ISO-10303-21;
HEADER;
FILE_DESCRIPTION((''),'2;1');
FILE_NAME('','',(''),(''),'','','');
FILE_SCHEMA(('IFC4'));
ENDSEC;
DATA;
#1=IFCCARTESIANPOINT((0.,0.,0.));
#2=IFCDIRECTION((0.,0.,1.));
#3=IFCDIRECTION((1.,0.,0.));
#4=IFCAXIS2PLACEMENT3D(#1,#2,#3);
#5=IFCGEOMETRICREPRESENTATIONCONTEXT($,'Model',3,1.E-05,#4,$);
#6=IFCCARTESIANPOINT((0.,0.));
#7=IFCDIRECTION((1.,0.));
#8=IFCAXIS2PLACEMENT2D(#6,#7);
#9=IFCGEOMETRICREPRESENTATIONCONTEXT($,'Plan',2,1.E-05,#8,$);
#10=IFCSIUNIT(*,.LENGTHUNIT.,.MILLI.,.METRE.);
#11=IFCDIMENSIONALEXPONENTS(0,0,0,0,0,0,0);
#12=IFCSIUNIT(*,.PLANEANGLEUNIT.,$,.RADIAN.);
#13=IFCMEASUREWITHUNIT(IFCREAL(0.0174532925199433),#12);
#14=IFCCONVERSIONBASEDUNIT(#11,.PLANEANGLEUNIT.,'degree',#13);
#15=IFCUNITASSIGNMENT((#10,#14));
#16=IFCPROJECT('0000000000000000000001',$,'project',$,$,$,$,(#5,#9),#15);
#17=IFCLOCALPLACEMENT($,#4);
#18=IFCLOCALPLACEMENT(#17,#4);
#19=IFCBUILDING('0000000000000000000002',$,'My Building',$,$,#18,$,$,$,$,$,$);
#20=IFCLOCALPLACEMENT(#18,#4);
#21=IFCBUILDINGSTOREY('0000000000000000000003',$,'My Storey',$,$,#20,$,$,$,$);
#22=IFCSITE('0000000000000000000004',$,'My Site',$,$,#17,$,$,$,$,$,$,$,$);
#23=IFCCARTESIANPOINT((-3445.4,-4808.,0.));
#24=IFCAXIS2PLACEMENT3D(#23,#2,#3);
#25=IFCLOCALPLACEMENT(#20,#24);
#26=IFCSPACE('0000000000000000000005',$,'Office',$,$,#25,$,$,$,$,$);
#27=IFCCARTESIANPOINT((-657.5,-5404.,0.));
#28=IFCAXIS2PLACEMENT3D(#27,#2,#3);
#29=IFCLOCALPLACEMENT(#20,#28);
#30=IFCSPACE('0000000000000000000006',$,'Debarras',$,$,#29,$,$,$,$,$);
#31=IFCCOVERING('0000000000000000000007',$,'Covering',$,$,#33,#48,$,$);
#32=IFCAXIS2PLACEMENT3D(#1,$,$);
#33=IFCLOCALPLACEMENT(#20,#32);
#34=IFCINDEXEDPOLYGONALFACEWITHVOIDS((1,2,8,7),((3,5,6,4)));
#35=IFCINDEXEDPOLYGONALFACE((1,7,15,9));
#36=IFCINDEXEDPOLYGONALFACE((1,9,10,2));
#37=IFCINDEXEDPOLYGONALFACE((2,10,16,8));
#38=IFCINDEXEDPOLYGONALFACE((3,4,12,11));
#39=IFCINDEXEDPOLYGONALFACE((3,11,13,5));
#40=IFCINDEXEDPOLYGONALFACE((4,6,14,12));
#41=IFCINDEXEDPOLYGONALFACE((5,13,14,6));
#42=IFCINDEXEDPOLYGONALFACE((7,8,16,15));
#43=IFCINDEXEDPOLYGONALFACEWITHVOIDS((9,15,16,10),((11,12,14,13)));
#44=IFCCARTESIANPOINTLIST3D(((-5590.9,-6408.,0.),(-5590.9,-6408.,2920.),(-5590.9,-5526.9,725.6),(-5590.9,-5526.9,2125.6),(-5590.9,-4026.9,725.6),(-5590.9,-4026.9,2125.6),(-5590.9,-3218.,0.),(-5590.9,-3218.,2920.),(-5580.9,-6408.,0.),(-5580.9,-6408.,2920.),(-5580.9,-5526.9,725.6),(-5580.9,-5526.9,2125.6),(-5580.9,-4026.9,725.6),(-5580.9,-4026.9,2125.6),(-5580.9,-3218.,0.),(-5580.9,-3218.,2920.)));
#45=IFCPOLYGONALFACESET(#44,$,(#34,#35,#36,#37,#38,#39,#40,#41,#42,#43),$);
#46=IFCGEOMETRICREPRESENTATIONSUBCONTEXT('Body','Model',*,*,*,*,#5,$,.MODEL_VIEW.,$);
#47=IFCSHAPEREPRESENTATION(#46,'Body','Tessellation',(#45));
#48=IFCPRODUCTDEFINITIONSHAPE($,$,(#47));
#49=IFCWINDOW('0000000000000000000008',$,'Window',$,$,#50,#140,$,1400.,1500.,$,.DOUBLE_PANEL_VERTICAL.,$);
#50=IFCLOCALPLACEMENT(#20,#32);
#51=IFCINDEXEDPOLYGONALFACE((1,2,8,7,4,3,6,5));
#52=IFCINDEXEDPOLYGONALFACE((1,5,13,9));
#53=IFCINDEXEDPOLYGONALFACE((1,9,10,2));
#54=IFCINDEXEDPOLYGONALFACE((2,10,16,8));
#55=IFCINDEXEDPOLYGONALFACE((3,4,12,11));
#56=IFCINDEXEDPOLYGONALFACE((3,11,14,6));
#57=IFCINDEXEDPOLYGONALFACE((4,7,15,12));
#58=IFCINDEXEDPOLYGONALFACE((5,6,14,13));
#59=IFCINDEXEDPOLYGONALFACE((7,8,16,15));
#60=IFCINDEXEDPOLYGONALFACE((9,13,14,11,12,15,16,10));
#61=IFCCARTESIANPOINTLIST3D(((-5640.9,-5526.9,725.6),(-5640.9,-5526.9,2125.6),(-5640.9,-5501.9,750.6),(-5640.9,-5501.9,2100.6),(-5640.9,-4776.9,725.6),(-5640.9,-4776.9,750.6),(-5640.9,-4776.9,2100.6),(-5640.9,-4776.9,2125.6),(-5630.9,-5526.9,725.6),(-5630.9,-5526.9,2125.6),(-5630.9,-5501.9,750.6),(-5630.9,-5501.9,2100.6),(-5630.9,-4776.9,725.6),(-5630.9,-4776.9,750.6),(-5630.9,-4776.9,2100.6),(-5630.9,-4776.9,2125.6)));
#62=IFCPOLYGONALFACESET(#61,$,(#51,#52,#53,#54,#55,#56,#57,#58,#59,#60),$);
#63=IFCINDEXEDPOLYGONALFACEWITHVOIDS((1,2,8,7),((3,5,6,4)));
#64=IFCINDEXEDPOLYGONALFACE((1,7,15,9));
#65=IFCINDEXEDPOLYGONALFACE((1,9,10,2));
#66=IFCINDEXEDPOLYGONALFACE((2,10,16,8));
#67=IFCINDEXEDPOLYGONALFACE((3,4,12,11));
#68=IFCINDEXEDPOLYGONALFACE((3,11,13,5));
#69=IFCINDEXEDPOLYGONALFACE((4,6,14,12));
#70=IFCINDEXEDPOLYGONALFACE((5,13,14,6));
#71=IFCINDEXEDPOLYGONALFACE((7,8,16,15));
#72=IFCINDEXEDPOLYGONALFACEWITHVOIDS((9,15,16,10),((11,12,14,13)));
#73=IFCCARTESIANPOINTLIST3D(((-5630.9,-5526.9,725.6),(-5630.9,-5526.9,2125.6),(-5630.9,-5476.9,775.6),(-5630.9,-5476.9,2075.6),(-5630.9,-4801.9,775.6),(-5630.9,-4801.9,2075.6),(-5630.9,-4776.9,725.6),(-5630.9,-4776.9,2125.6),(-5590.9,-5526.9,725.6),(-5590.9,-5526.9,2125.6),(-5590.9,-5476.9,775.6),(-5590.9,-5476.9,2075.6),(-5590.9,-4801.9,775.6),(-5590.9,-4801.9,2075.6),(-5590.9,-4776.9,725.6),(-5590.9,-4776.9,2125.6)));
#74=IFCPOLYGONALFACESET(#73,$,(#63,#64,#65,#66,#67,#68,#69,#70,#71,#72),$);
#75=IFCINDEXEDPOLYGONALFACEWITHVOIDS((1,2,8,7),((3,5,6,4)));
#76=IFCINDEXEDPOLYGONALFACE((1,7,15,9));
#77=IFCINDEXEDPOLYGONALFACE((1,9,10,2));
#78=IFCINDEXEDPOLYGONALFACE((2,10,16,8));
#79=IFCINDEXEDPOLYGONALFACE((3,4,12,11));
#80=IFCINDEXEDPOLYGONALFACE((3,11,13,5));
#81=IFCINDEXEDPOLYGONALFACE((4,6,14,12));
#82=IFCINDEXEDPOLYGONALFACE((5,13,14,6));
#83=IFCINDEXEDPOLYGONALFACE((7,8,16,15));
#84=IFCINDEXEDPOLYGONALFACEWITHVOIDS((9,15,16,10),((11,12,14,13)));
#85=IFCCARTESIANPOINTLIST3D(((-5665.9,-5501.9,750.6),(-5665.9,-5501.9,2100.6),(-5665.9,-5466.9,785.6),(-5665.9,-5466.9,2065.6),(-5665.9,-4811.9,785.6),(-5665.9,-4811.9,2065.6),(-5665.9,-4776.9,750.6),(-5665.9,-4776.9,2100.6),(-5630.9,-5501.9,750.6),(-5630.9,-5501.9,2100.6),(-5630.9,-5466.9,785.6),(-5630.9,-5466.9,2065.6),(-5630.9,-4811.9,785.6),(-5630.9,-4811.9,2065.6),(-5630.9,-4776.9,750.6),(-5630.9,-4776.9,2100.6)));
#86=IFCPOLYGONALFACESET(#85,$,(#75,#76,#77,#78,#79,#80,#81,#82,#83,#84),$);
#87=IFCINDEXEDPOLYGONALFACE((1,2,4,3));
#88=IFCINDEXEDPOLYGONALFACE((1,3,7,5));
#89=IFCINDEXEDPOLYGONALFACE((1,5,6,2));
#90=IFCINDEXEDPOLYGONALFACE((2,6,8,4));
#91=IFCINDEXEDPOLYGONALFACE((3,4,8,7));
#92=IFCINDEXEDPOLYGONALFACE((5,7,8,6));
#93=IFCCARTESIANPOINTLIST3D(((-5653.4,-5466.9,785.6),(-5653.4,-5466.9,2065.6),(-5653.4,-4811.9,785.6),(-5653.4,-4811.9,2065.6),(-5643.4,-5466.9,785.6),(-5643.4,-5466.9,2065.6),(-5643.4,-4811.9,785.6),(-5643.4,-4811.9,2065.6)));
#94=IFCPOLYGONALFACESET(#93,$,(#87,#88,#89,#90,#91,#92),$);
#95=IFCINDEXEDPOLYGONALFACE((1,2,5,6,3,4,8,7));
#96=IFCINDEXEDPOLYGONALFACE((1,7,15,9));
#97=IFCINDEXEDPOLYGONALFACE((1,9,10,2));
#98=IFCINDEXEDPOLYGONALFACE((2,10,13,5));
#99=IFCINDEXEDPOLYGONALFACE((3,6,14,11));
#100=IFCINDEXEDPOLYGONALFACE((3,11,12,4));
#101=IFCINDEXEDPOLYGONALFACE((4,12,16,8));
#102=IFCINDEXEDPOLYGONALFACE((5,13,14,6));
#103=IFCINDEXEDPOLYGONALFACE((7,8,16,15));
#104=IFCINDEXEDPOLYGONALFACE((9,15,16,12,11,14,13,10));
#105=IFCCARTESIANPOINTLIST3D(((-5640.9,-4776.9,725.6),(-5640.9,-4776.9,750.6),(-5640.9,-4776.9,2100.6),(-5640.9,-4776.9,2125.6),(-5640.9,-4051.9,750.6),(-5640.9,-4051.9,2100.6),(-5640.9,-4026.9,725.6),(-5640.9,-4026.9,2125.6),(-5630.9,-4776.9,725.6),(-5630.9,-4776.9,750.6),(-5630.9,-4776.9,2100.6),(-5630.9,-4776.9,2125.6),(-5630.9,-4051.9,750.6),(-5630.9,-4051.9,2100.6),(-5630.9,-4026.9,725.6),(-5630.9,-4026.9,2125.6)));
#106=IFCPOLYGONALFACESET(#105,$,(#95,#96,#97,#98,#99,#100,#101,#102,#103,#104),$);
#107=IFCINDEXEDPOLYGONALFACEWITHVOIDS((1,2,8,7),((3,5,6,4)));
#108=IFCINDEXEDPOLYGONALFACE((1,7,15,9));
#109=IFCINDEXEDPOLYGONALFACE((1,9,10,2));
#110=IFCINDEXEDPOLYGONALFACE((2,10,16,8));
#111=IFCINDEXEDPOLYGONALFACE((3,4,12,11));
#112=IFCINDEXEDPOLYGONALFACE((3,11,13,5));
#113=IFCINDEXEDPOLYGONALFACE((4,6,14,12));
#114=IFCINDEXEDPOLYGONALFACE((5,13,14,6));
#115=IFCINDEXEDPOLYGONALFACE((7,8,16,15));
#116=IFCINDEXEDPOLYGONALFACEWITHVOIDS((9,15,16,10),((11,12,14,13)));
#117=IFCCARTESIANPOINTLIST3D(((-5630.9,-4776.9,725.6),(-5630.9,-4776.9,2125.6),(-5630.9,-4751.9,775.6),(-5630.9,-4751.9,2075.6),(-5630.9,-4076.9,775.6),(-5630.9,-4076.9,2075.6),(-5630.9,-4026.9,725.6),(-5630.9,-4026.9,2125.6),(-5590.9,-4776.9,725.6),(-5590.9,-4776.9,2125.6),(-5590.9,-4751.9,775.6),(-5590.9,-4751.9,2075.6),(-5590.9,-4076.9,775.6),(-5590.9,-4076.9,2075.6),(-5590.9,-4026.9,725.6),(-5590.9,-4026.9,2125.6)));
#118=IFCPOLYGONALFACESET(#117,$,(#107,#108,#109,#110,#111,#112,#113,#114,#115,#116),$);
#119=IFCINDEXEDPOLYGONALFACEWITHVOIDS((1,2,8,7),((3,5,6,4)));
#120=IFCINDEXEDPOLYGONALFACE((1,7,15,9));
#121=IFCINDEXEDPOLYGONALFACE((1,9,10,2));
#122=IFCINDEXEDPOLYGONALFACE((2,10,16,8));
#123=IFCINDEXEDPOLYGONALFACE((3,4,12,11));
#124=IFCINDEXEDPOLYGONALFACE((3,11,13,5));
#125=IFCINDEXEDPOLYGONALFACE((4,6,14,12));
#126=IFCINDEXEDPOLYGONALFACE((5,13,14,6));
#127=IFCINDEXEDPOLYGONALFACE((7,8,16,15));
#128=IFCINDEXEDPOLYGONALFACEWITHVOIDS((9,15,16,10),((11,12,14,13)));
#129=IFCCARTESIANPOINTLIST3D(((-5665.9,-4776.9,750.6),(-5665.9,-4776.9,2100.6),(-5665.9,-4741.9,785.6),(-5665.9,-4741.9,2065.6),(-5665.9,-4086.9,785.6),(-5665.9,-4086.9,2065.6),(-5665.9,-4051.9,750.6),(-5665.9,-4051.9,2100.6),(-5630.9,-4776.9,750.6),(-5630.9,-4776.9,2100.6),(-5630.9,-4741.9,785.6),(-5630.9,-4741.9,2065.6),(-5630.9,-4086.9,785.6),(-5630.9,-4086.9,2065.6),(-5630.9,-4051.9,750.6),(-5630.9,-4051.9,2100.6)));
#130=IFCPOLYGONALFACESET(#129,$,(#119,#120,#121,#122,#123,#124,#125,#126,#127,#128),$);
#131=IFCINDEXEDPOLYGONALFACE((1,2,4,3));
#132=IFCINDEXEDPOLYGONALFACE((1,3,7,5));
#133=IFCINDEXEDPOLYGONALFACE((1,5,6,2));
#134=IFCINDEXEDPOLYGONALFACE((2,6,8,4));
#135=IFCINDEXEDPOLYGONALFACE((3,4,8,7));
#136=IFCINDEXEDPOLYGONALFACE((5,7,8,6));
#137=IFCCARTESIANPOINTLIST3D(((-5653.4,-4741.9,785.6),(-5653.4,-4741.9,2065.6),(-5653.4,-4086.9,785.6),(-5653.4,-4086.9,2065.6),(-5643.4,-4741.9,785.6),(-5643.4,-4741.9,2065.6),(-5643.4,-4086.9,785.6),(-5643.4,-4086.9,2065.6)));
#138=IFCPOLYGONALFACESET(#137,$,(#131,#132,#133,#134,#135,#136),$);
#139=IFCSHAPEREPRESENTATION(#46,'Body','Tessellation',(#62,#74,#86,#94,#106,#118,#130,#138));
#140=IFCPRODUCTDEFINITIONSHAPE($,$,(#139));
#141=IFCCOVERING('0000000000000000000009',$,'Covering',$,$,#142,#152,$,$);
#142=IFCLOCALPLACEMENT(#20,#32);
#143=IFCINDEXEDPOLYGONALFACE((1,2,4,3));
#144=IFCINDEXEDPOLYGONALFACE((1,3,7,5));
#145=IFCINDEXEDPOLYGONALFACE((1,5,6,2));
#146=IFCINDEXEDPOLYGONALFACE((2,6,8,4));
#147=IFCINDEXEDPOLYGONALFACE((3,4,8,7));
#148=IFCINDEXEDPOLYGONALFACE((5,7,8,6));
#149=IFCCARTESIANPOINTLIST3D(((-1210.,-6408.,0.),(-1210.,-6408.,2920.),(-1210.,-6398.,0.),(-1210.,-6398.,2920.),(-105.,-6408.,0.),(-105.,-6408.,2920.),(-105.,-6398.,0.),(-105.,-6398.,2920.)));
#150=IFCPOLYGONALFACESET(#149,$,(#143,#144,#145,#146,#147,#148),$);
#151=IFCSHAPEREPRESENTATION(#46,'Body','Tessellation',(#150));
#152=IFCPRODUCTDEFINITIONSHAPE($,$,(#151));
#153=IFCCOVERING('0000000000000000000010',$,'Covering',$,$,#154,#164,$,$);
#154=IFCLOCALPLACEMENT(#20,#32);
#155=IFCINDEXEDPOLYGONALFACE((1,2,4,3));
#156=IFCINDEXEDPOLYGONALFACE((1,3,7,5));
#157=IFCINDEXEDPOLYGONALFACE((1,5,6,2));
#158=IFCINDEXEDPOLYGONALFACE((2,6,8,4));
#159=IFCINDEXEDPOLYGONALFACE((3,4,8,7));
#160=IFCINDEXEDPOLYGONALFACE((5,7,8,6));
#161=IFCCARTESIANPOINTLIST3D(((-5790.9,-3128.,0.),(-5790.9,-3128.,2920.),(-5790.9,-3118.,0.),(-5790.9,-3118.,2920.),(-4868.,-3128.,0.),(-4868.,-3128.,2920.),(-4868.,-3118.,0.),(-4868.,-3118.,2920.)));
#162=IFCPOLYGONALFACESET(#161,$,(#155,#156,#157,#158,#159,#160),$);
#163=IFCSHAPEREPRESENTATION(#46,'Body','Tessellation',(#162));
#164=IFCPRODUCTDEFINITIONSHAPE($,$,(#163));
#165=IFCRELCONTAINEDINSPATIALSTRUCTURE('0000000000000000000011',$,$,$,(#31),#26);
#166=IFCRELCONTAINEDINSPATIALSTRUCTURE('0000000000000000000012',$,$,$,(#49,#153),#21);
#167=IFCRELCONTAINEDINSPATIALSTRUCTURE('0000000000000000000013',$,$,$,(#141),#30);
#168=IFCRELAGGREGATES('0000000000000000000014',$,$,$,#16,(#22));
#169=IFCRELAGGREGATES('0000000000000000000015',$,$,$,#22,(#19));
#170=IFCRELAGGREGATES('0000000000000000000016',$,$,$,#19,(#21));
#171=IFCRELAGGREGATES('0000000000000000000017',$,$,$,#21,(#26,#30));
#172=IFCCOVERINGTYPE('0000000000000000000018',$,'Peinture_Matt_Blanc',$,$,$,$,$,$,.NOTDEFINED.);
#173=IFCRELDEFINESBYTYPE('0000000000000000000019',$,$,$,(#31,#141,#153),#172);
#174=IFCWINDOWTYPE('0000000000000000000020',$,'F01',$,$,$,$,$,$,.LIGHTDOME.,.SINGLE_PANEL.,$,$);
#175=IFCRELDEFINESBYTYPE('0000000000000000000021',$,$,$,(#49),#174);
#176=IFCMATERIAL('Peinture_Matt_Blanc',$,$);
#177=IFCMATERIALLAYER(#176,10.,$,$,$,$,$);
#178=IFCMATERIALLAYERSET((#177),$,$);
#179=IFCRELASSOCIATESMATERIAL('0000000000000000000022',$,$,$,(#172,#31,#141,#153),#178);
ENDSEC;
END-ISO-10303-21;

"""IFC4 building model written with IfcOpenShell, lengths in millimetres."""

from ifc_helpers import new_model, entity, si_unit, converted_unit, frame, origin_with_axes, origin_2d_with_axis, place, context, subcontext, project, spatial, line, indexed_curve, outline, extrude, clip, halfspace, shape, source, transform, mapped, material, layer, layer_set, layer_usage, type_object, type_shapes, element, fill, save


model = new_model("IFC4")

# Units and contexts
model_context = context("Model", 3, precision=1e-05, world=origin_with_axes())
plan_context = context("Plan", 2, precision=1e-05, world=origin_2d_with_axis())
body_context_1 = subcontext(model_context, "Body", "Model", "MODEL_VIEW")
body_context_2 = subcontext(plan_context, "Body", "Plan", "PLAN_VIEW")
ifc_project = project(units=[si_unit("LENGTHUNIT", "METRE", prefix="MILLI"), converted_unit("PLANEANGLEUNIT", "degree", entity("IfcReal", 0.0174532925199433), si_unit("PLANEANGLEUNIT", "RADIAN"), dimensions=[0, 0, 0, 0, 0, 0, 0])], contexts=[model_context, plan_context])

# Site, building, storey
site_placement = place(None, origin_with_axes())
site = spatial("IfcSite", under=ifc_project, at=site_placement, Name="My Site")
building_placement = place(site_placement, origin_with_axes())
building = spatial("IfcBuilding", under=site, at=building_placement, Name="My Building")
storey_placement = place(building_placement, origin_with_axes())
storey = spatial("IfcBuildingStorey", under=building, at=storey_placement, Name="My Storey")

# Shared definitions
ifc_material_1 = material(Name="Peinture_Matt_Blanc")
ifc_layer_1 = layer(ifc_material_1, 10.0)
ifc_layer_set_1 = layer_set([ifc_layer_1])
covering_type_1 = type_object("IfcCoveringType", Name="Peinture_Matt_Blanc", PredefinedType="NOTDEFINED", material=ifc_layer_set_1)

# Shared definitions
space_1_placement = place(storey_placement, frame((-3445.4, -4808.0, 0.0), z_axis=(0.0, 0.0, 1.0), x_axis=(1.0, 0.0, 0.0)))
space_1 = spatial("IfcSpace", under=storey, at=space_1_placement, Name="Office")

# Covering, opening, window
ifc_layer_usage_1 = layer_usage(ifc_layer_set_1, "AXIS2", "POSITIVE", 0.0)
covering_1_placement = place(space_1_placement, frame((-2135.4, -1600.0, 0.0), z_axis=(0.0, 0.0, 1.0), x_axis=(0.000002, 1.0, 0.0)))
covering_1 = element("IfcCovering", 1, at=covering_1_placement, inside=space_1, type_object=covering_type_1, material=ifc_layer_usage_1, Name="Covering", context=body_context_1, shape_type="Clipping", body=[
    clip(extrude(outline(indexed_curve([(0.0, 0.0), (0.0, 10.0), (3190.0, 10.0), (3190.0, 0.0), (0.0, 0.0)], self_intersect=False)), origin_with_axes(), (0.0, 0.0, 1.0), 2920.0), halfspace(frame((0.0, 0.0, 2920.0), z_axis=(0.0, 0.0, 1.0), x_axis=(-1.0, 0.0, 0.0)), False)),
])
shared_shape_1 = source(origin_with_axes(), body_context_1, "Body", "SweptSolid", [
    extrude(outline(indexed_curve([(0.0, 0.0), (1500.0, 0.0), (1500.0, 1400.0), (0.0, 1400.0)], segments=[line(1, 2, 3, 4, 1)])), frame((0.0, -100.0, 0.0), z_axis=(0.0, -1.0, 0.0), x_axis=(1.0, 0.0, 0.0)), (0.0, 0.0, -1.0), 210.0),
])
opening_1_placement = place(covering_1_placement, frame((881.1, 10.0, 725.6), z_axis=(0.0, 0.0, 1.0), x_axis=(1.0, 0.0, 0.0)))
opening_1 = element("IfcOpeningElement", 2, at=opening_1_placement, cuts=covering_1, PredefinedType="OPENING", context=body_context_1, shape_type="MappedRepresentation", body=[
    mapped(shared_shape_1, transform((0.0, 0.0, 0.0), x_axis=(1.0, 0.0, 0.0), y_axis=(0.0, 1.0, 0.0), z_axis=(0.0, 0.0, 1.0), scale=1.0)),
])
window_type = type_object("IfcWindowType", Name="F01", PartitioningType="SINGLE_PANEL", PredefinedType="LIGHTDOME")
shared_shape_2 = source(origin_with_axes(), body_context_1, "Body", "SweptSolid", [
    extrude(outline(indexed_curve([(750.0, 0.0), (0.0, 0.0), (0.0, 1400.0), (750.0, 1400.0), (750.0, 1375.0), (25.0, 1375.0), (25.0, 25.0), (750.0, 25.0)], segments=[line(1, 2, 3, 4, 5, 6, 7, 8, 1)])), frame((0.0, 90.0, 0.0), z_axis=(0.0, -1.0, 0.0), x_axis=(1.0, 0.0, 0.0)), (0.0, 0.0, -1.0), 10.0),
    extrude(outline(indexed_curve([(0.0, 0.0), (750.0, 0.0), (750.0, 1400.0), (0.0, 1400.0)], segments=[line(1, 2, 3, 4, 1)]), holes=[indexed_curve([(50.0, 50.0), (725.0, 50.0), (725.0, 1350.0), (50.0, 1350.0)], segments=[line(1, 2, 3, 4, 1)])]), frame((0.0, 50.0, 0.0), z_axis=(0.0, -1.0, 0.0), x_axis=(1.0, 0.0, 0.0)), (0.0, 0.0, -1.0), 40.0),
    extrude(outline(indexed_curve([(0.0, 0.0), (725.0, 0.0), (725.0, 1350.0), (0.0, 1350.0)], segments=[line(1, 2, 3, 4, 1)]), holes=[indexed_curve([(35.0, 35.0), (690.0, 35.0), (690.0, 1315.0), (35.0, 1315.0)], segments=[line(1, 2, 3, 4, 1)])]), frame((25.0, 90.0, 25.0), z_axis=(0.0, -1.0, 0.0), x_axis=(1.0, 0.0, 0.0)), (0.0, 0.0, -1.0), 35.0),
    extrude(outline(indexed_curve([(35.0, 35.0), (690.0, 35.0), (690.0, 1315.0), (35.0, 1315.0)], segments=[line(1, 2, 3, 4, 1)])), frame((25.0, 102.5, 25.0), z_axis=(0.0, -1.0, 0.0), x_axis=(1.0, 0.0, 0.0)), (0.0, 0.0, -1.0), 10.0),
    extrude(outline(indexed_curve([(0.0, 1400.0), (750.0, 1400.0), (750.0, 0.0), (0.0, 0.0), (0.0, 25.0), (725.0, 25.0), (725.0, 1375.0), (0.0, 1375.0)], segments=[line(1, 2, 3, 4, 5, 6, 7, 8, 1)])), frame((750.0, 90.0, 0.0), z_axis=(0.0, -1.0, 0.0), x_axis=(1.0, 0.0, 0.0)), (0.0, 0.0, -1.0), 10.0),
    extrude(outline(indexed_curve([(0.0, 0.0), (750.0, 0.0), (750.0, 1400.0), (0.0, 1400.0)], segments=[line(1, 2, 3, 4, 1)]), holes=[indexed_curve([(25.0, 50.0), (700.0, 50.0), (700.0, 1350.0), (25.0, 1350.0)], segments=[line(1, 2, 3, 4, 1)])]), frame((750.0, 50.0, 0.0), z_axis=(0.0, -1.0, 0.0), x_axis=(1.0, 0.0, 0.0)), (0.0, 0.0, -1.0), 40.0),
    extrude(outline(indexed_curve([(0.0, 0.0), (725.0, 0.0), (725.0, 1350.0), (0.0, 1350.0)], segments=[line(1, 2, 3, 4, 1)]), holes=[indexed_curve([(35.0, 35.0), (690.0, 35.0), (690.0, 1315.0), (35.0, 1315.0)], segments=[line(1, 2, 3, 4, 1)])]), frame((750.0, 90.0, 25.0), z_axis=(0.0, -1.0, 0.0), x_axis=(1.0, 0.0, 0.0)), (0.0, 0.0, -1.0), 35.0),
    extrude(outline(indexed_curve([(35.0, 35.0), (690.0, 35.0), (690.0, 1315.0), (35.0, 1315.0)], segments=[line(1, 2, 3, 4, 1)])), frame((750.0, 102.5, 25.0), z_axis=(0.0, -1.0, 0.0), x_axis=(1.0, 0.0, 0.0)), (0.0, 0.0, -1.0), 10.0),
])
shared_shape_3 = source(origin_with_axes(), body_context_2, "Body", "Curve2D", [
    entity("IfcIndexedPolyCurve", entity("IfcCartesianPointList2D", [[50.0, 50.0], [725.0, 50.0]])),
    entity("IfcIndexedPolyCurve", entity("IfcCartesianPointList2D", [[0.0, 100.0], [25.0, 100.0], [25.0, 90.0], [50.0, 90.0], [50.0, 50.0], [0.0, 50.0]]), [entity("IfcLineIndex", [1, 2, 3, 4, 5, 6, 1])]),
    entity("IfcIndexedPolyCurve", entity("IfcCartesianPointList2D", [[750.0, 100.0], [750.0, 100.0], [750.0, 90.0], [725.0, 90.0], [725.0, 50.0], [750.0, 50.0]])),
    entity("IfcIndexedPolyCurve", entity("IfcCartesianPointList2D", [[25.0, 90.0], [60.0, 90.0], [60.0, 125.0], [25.0, 125.0]]), [entity("IfcLineIndex", [1, 2, 3, 4, 1])]),
    entity("IfcIndexedPolyCurve", entity("IfcCartesianPointList2D", [[750.0, 90.0], [715.0, 90.0], [715.0, 125.0], [750.0, 125.0]]), [entity("IfcLineIndex", [1, 2, 3, 4, 1])]),
    entity("IfcIndexedPolyCurve", entity("IfcCartesianPointList2D", [[60.0, 90.0], [715.0, 90.0]])),
    entity("IfcIndexedPolyCurve", entity("IfcCartesianPointList2D", [[60.0, 125.0], [715.0, 125.0]])),
    entity("IfcIndexedPolyCurve", entity("IfcCartesianPointList2D", [[60.0, 107.5], [715.0, 107.5]])),
    entity("IfcIndexedPolyCurve", entity("IfcCartesianPointList2D", [[775.0, 50.0], [1450.0, 50.0]])),
    entity("IfcIndexedPolyCurve", entity("IfcCartesianPointList2D", [[750.0, 100.0], [750.0, 100.0], [750.0, 90.0], [775.0, 90.0], [775.0, 50.0], [750.0, 50.0]])),
    entity("IfcIndexedPolyCurve", entity("IfcCartesianPointList2D", [[1500.0, 100.0], [1475.0, 100.0], [1475.0, 90.0], [1450.0, 90.0], [1450.0, 50.0], [1500.0, 50.0]]), [entity("IfcLineIndex", [1, 2, 3, 4, 5, 6, 1])]),
    entity("IfcIndexedPolyCurve", entity("IfcCartesianPointList2D", [[750.0, 90.0], [785.0, 90.0], [785.0, 125.0], [750.0, 125.0]]), [entity("IfcLineIndex", [1, 2, 3, 4, 1])]),
    entity("IfcIndexedPolyCurve", entity("IfcCartesianPointList2D", [[1475.0, 90.0], [1440.0, 90.0], [1440.0, 125.0], [1475.0, 125.0]]), [entity("IfcLineIndex", [1, 2, 3, 4, 1])]),
    entity("IfcIndexedPolyCurve", entity("IfcCartesianPointList2D", [[785.0, 90.0], [1440.0, 90.0]])),
    entity("IfcIndexedPolyCurve", entity("IfcCartesianPointList2D", [[785.0, 125.0], [1440.0, 125.0]])),
    entity("IfcIndexedPolyCurve", entity("IfcCartesianPointList2D", [[785.0, 107.5], [1440.0, 107.5]])),
])
type_shapes(window_type, [shared_shape_2, shared_shape_3])
window_placement = place(opening_1_placement, frame((0.0, -50.0, 0.0), z_axis=(0.0, 0.0, 1.0), x_axis=(1.0, 0.0, 0.0)))
window = element("IfcWindow", 3, at=window_placement, inside=storey, type_object=window_type, Name="Window", OverallHeight=1400.0, OverallWidth=1500.0, PartitioningType="DOUBLE_PANEL_VERTICAL", shapes=[
    shape(body_context_1, "Body", "MappedRepresentation", [mapped(shared_shape_2, transform((0.0, 0.0, 0.0), x_axis=(1.0, 0.0, 0.0), y_axis=(0.0, 1.0, 0.0), z_axis=(0.0, 0.0, 1.0), scale=1.0))]),
    shape(body_context_2, "Body", "MappedRepresentation", [mapped(shared_shape_3, transform((0.0, 0.0, 0.0), x_axis=(1.0, 0.0, 0.0), y_axis=(0.0, 1.0, 0.0), z_axis=(0.0, 0.0, 1.0), scale=1.0))]),
])
fill(opening_1, window)

# Shared definitions
space_2_placement = place(storey_placement, frame((-657.5, -5404.0, 0.0), z_axis=(0.0, 0.0, 1.0), x_axis=(1.0, 0.0, 0.0)))
space_2 = spatial("IfcSpace", under=storey, at=space_2_placement, Name="Debarras")

# Coverings
ifc_layer_usage_2 = layer_usage(ifc_layer_set_1, "AXIS2", "POSITIVE", 0.0)
covering_2_placement = place(space_2_placement, frame((552.5, -994.0, 0.0), z_axis=(0.0, 0.0, 1.0), x_axis=(-1.0, 0.000003, 0.0)))
element("IfcCovering", 4, at=covering_2_placement, inside=space_2, type_object=covering_type_1, material=ifc_layer_usage_2, Name="Covering", context=body_context_1, shape_type="Clipping", body=[
    clip(extrude(outline(indexed_curve([(0.0, 0.0), (0.0, 10.0), (1105.0, 10.0), (1105.0, 0.0), (0.0, 0.0)], self_intersect=False)), origin_with_axes(), (0.0, 0.0, 1.0), 2920.0), halfspace(frame((0.0, 0.0, 2920.0), z_axis=(0.0, 0.0, 1.0), x_axis=(-1.0, 0.0, 0.0)), False)),
])
ifc_layer_usage_3 = layer_usage(ifc_layer_set_1, "AXIS2", "POSITIVE", 0.0)
covering_3_placement = place(storey_placement, frame((-4868.0, -3118.0, 0.0), z_axis=(0.0, 0.0, 1.0), x_axis=(-1.0, 0.000001, 0.0)))
element("IfcCovering", 5, at=covering_3_placement, inside=storey, type_object=covering_type_1, material=ifc_layer_usage_3, Name="Covering", context=body_context_1, shape_type="Clipping", body=[
    clip(extrude(outline(indexed_curve([(0.0, 0.0), (0.0, 10.0), (922.9, 10.0), (922.9, 0.0), (0.0, 0.0)], self_intersect=False)), origin_with_axes(), (0.0, 0.0, 1.0), 2920.0), halfspace(frame((0.0, 0.0, 2920.0), z_axis=(0.0, 0.0, 1.0), x_axis=(-1.0, 0.0, 0.0)), False)),
])

save(model, "model.ifc")
